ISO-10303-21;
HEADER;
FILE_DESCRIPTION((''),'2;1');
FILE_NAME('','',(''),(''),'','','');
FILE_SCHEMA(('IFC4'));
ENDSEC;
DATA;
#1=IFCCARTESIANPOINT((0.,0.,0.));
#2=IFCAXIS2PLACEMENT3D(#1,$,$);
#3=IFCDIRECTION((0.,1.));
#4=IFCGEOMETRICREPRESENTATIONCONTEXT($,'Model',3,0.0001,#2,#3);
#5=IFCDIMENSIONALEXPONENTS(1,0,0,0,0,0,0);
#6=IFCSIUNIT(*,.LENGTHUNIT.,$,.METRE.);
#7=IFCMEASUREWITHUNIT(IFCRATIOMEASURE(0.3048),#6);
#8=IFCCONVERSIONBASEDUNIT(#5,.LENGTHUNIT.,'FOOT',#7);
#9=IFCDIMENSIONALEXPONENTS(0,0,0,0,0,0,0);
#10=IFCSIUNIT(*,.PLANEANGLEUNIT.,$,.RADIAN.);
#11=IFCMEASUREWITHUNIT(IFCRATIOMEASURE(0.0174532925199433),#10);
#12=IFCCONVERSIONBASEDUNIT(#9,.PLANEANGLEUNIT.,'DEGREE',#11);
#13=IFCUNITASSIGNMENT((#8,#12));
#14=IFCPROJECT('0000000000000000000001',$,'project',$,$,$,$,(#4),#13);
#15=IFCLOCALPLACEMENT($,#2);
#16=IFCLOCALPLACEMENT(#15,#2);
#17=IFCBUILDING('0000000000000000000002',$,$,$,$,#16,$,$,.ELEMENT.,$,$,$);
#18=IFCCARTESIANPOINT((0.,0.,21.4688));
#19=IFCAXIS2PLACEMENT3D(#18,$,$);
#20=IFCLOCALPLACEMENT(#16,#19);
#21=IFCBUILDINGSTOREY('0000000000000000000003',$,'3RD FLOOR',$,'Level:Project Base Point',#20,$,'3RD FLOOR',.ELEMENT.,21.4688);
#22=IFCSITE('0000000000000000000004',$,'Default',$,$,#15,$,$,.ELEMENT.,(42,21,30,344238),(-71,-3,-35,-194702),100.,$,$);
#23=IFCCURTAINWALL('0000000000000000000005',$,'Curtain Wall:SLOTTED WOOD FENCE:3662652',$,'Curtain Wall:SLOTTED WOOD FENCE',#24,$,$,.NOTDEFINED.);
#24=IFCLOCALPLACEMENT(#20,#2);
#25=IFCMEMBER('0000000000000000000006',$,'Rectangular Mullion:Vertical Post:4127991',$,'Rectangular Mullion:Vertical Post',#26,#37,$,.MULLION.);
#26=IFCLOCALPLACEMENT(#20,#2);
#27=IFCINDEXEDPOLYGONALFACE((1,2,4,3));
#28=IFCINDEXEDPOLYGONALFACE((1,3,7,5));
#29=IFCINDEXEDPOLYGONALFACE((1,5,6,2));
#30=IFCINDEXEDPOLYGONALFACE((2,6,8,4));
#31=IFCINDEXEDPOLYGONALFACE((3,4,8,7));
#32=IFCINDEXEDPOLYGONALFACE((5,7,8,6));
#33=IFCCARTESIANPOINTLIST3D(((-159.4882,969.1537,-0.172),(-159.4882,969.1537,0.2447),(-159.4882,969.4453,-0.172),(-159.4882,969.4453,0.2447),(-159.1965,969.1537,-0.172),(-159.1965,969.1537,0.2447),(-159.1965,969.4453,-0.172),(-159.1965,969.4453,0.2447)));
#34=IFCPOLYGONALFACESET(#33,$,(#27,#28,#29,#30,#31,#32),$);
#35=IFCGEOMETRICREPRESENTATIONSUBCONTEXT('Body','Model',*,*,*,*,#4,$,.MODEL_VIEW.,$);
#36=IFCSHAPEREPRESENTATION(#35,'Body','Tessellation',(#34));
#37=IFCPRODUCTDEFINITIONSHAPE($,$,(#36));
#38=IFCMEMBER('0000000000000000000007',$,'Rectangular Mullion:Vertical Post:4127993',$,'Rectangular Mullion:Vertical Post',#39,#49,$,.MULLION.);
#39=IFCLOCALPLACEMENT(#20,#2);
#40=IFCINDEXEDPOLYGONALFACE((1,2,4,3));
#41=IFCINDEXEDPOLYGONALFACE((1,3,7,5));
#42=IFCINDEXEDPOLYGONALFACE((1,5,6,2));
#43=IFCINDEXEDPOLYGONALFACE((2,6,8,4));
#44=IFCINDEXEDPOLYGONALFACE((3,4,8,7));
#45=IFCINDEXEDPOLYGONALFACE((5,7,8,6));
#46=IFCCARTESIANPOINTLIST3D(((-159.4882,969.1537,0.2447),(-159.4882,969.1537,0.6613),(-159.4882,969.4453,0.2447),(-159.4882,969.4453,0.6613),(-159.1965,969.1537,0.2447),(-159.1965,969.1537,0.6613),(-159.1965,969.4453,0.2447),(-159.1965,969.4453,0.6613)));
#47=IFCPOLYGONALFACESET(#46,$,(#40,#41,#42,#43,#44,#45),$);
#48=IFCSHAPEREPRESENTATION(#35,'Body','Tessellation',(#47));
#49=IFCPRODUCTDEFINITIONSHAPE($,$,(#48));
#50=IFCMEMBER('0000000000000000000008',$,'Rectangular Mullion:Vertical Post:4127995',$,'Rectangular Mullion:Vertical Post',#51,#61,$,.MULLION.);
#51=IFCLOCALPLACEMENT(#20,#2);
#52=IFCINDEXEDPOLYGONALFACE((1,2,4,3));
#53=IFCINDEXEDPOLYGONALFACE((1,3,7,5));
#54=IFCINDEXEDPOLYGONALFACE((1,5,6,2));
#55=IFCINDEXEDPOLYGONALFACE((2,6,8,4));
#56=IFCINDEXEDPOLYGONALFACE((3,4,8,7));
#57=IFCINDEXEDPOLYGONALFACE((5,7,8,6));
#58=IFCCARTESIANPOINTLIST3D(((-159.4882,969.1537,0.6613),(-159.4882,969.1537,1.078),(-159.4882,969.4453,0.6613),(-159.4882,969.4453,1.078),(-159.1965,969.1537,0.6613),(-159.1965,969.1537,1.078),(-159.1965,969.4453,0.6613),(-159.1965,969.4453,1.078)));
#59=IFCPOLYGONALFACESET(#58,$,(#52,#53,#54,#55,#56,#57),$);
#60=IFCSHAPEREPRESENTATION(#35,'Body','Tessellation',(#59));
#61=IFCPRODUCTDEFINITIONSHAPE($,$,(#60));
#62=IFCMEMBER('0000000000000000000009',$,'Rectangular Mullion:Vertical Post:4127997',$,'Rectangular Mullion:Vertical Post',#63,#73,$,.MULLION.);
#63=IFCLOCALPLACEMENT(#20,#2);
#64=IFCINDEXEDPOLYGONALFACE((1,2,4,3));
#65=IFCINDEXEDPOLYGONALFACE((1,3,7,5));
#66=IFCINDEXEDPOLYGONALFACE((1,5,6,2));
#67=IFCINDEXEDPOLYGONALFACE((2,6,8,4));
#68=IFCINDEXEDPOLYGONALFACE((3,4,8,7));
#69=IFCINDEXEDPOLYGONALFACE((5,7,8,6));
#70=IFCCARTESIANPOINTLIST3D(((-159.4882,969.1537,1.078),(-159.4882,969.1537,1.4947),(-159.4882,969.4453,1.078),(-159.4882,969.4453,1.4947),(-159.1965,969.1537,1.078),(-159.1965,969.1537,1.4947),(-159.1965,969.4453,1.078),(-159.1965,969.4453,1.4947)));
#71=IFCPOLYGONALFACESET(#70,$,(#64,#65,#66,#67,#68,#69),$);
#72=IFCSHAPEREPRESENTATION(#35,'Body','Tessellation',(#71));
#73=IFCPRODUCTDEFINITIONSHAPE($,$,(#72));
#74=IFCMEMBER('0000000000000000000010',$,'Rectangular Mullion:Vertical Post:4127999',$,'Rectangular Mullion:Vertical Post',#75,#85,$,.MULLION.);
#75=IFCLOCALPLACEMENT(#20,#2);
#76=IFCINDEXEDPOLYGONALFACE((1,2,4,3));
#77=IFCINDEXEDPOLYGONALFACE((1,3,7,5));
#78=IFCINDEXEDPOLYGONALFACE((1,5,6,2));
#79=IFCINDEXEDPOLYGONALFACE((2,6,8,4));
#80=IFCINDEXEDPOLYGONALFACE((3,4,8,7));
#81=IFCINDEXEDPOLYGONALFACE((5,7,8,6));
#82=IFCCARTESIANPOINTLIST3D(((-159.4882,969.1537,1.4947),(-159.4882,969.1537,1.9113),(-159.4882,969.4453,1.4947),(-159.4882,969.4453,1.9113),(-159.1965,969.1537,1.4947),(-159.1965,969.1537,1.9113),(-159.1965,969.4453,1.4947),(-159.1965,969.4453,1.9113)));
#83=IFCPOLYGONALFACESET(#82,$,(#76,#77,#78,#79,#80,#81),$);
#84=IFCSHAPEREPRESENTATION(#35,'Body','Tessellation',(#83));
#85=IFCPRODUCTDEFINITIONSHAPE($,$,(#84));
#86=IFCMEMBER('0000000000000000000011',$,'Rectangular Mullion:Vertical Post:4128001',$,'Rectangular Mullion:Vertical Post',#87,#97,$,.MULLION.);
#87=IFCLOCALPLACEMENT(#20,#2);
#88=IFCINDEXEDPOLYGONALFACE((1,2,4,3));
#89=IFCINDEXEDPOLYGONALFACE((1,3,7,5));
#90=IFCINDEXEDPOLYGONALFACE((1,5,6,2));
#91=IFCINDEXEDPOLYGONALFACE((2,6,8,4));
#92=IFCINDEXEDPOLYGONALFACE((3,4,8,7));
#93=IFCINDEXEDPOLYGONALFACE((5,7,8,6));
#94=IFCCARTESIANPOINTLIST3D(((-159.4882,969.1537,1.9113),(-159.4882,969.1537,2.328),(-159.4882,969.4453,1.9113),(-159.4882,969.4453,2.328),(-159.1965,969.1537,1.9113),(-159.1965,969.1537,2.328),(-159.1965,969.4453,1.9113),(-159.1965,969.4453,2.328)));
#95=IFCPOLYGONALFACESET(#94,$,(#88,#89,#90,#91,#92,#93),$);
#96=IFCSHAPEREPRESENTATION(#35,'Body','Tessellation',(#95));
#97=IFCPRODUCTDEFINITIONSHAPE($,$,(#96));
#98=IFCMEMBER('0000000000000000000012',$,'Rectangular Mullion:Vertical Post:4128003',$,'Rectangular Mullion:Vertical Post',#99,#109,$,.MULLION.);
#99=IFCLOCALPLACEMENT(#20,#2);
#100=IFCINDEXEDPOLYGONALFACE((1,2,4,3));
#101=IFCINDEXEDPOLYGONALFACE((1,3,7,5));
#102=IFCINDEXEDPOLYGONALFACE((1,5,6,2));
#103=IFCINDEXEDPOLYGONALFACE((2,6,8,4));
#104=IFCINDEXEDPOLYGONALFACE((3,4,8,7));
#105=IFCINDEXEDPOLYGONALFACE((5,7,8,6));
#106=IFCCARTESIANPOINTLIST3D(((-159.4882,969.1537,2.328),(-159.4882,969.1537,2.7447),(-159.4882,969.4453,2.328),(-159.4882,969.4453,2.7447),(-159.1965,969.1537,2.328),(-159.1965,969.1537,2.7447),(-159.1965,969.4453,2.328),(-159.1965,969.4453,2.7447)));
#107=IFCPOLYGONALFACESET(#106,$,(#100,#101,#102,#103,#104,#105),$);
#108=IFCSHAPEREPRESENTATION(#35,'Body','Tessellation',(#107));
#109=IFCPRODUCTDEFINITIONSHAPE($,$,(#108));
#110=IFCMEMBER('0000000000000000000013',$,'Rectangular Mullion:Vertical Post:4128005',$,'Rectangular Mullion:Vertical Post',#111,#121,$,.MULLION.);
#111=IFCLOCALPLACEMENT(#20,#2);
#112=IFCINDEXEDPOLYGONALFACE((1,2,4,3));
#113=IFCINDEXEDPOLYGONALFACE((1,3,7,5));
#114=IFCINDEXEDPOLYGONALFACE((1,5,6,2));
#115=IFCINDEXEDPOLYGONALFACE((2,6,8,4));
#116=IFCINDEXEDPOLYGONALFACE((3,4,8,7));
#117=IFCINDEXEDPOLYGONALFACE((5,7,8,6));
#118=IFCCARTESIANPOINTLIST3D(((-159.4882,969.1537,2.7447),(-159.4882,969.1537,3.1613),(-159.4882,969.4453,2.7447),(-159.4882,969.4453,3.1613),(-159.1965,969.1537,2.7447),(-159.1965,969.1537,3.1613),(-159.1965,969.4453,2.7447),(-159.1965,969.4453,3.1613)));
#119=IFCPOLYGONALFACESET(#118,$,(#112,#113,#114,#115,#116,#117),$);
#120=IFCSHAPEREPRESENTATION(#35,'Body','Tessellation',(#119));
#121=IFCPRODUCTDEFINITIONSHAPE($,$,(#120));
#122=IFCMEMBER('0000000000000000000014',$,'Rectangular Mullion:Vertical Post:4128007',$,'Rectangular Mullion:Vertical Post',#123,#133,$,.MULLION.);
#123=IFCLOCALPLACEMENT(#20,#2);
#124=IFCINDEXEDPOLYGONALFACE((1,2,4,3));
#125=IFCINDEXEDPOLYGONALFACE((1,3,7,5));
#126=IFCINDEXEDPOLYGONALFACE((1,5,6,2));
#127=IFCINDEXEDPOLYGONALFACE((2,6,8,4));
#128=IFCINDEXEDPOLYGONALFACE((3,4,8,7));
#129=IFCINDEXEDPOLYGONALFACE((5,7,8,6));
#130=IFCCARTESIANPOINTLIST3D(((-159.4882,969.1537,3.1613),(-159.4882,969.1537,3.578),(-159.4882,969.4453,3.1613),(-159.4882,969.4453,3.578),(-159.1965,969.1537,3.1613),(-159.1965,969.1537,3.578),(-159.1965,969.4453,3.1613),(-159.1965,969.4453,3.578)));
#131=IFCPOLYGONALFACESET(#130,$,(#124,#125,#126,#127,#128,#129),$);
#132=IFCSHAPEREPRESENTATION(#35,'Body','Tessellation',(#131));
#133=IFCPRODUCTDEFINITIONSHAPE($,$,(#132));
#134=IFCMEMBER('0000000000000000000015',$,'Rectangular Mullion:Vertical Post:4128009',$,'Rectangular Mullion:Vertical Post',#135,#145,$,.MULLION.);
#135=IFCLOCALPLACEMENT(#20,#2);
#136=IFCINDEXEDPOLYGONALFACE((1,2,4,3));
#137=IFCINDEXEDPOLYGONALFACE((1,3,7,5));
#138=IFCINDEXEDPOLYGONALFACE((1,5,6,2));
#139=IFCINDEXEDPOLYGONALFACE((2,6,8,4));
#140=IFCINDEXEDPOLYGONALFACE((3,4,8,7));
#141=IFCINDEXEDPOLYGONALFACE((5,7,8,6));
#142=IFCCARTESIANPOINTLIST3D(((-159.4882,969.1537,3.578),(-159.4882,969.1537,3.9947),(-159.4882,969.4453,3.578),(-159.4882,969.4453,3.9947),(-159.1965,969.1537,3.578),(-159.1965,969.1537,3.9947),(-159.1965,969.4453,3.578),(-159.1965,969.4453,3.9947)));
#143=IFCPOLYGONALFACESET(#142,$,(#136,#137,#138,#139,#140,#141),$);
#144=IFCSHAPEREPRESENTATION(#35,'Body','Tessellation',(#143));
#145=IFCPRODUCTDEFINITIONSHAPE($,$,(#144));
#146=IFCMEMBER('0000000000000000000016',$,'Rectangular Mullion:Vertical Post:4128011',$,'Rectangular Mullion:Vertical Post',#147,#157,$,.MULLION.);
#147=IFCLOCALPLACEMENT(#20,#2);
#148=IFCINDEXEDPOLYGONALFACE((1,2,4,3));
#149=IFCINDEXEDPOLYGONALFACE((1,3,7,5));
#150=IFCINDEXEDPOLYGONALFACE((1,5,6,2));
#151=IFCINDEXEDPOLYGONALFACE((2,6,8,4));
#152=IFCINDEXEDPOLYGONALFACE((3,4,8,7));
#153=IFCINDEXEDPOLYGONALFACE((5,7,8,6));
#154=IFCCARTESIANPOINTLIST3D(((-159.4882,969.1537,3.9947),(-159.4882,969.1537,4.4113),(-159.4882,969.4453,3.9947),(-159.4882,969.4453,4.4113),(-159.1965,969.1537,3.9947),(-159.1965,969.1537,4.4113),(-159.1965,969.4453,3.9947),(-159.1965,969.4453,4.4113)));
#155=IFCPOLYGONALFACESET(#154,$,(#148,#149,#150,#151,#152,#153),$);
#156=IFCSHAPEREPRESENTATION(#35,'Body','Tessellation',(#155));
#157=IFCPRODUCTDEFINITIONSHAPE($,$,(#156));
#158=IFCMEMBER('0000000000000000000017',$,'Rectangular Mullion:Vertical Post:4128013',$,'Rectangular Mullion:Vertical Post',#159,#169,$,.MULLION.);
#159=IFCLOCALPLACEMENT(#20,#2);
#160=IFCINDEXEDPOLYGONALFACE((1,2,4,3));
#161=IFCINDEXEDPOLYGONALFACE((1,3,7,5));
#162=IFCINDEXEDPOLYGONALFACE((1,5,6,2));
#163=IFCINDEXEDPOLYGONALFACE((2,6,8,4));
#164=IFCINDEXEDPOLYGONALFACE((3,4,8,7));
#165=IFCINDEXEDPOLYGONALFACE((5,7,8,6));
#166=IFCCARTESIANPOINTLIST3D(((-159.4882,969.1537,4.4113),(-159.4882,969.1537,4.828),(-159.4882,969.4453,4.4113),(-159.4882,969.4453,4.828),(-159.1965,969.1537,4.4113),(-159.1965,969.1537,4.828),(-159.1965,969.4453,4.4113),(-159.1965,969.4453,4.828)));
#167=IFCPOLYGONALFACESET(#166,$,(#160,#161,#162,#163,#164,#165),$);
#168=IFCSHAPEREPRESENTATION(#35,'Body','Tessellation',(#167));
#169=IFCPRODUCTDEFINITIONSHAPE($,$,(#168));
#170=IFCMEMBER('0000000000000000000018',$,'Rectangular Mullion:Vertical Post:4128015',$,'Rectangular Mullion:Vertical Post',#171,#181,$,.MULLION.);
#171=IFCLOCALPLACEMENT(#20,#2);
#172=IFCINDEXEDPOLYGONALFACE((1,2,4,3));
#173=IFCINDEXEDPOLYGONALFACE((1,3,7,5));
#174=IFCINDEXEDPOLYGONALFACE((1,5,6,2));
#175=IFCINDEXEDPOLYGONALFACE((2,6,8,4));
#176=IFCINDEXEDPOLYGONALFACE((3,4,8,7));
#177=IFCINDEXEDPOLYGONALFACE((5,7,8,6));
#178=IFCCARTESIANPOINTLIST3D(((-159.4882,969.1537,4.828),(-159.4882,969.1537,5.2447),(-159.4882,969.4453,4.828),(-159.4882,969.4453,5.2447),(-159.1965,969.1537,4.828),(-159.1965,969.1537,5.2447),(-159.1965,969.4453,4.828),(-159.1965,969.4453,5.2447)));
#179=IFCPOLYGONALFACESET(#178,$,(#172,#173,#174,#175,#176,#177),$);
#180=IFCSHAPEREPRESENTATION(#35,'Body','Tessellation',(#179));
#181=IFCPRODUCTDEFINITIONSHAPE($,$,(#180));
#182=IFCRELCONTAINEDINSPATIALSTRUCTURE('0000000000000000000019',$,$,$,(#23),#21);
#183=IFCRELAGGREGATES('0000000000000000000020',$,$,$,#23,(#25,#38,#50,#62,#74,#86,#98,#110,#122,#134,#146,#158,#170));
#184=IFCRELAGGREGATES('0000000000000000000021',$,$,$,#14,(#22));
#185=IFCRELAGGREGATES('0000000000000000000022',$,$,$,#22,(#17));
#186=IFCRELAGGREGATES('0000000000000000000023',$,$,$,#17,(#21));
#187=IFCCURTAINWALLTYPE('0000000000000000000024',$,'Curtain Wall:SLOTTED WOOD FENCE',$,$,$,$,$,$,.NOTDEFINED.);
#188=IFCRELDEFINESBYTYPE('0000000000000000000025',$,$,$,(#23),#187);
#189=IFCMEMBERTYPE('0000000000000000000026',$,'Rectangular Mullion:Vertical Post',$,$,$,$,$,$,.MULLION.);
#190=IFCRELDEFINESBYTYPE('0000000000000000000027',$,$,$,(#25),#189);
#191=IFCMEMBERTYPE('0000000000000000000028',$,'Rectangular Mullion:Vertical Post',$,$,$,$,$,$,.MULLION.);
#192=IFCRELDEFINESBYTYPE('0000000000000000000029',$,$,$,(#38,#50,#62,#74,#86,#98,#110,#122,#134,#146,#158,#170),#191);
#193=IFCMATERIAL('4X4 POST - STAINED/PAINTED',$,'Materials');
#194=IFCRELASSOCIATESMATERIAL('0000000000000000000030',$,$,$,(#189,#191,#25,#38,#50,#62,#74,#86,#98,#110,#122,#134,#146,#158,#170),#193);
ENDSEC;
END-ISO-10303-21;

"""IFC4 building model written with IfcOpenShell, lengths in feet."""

from ifc_helpers import new_model, entity, si_unit, converted_unit, direction, frame, origin, origin_2d_with_axis, place, context, subcontext, project, spatial, rectangle, extrude, source, transform, mapped, material, material_profile, profile_set, profile_usage, type_object, type_shapes, element, aggregate, save


model = new_model("IFC4")

# Units and contexts
model_context = context("Model", 3, precision=0.0001, world=origin(), true_north=direction((0.0, 1.0)))
body_context = subcontext(model_context, "Body", "Model", "MODEL_VIEW")
ifc_project = project(units=[converted_unit("LENGTHUNIT", "FOOT", entity("IfcRatioMeasure", 0.3048), si_unit("LENGTHUNIT", "METRE"), dimensions=[1, 0, 0, 0, 0, 0, 0]), converted_unit("PLANEANGLEUNIT", "DEGREE", entity("IfcRatioMeasure", 0.0174532925199433), si_unit("PLANEANGLEUNIT", "RADIAN"), dimensions=[0, 0, 0, 0, 0, 0, 0])], contexts=[model_context])

# Site, building, storey
site_placement = place(None, origin())
site = spatial("IfcSite", under=ifc_project, at=site_placement, Name="Default", CompositionType="ELEMENT", RefLatitude=(42, 21, 30, 344238), RefLongitude=(-71, -3, -35, -194702), RefElevation=100.0)
building_placement = place(site_placement, origin())
building = spatial("IfcBuilding", under=site, at=building_placement, CompositionType="ELEMENT")
storey_placement = place(building_placement, frame((0.0, 0.0, 21.4688)))
storey = spatial("IfcBuildingStorey", under=building, at=storey_placement, Name="3RD FLOOR", ObjectType="Level:Project Base Point", LongName="3RD FLOOR", CompositionType="ELEMENT", Elevation=21.4688)

# Curtain wall, members
curtain_wall_type = type_object("IfcCurtainWallType", Name="Curtain Wall:SLOTTED WOOD FENCE", PredefinedType="NOTDEFINED")
curtain_wall_placement = place(storey_placement, frame((0.0, 0.0, -21.4688)))
curtain_wall = element("IfcCurtainWall", 1, at=curtain_wall_placement, inside=storey, type_object=curtain_wall_type, Name="Curtain Wall:SLOTTED WOOD FENCE:3662652", ObjectType="Curtain Wall:SLOTTED WOOD FENCE", PredefinedType="NOTDEFINED")
ifc_material = material(Name="4X4 POST - STAINED/PAINTED", Category="Materials")
ifc_material_profile = material_profile(ifc_material, rectangle(XDim=0.2917, YDim=0.2917, at=origin_2d_with_axis()), Name="Vertical Post")
ifc_profile_set = profile_set([ifc_material_profile], Name="Vertical Post")
ifc_profile_usage_1 = profile_usage(ifc_profile_set)
member_type_1 = type_object("IfcMemberType", Name="Rectangular Mullion:Vertical Post", PredefinedType="MULLION", material=ifc_profile_set)
shared_shape_1 = source(origin(), body_context, "Body", "SweptSolid", [
    extrude(rectangle(XDim=0.2917, YDim=0.2917, at=origin_2d_with_axis()), frame((0.0, -0.2083, -0.4167), z_axis=(0.0, 0.0, 1.0), x_axis=(0.0, -1.0, 0.0)), (0.0, 0.0, 1.0), 0.4167),
])
type_shapes(member_type_1, [shared_shape_1])
member_1_placement = place(storey_placement, frame((-159.5507, 969.2995, -0.172), z_axis=(0.0, 0.0, -1.0), x_axis=(0.0, -1.0, 0.0)))
member_1 = element("IfcMember", 2, at=member_1_placement, type_object=member_type_1, material=ifc_profile_usage_1, Name="Rectangular Mullion:Vertical Post:4127991", ObjectType="Rectangular Mullion:Vertical Post", PredefinedType="MULLION", context=body_context, shape_type="MappedRepresentation", body=[
    mapped(shared_shape_1, transform((0.0, 0.0, 0.0), scale=1.0)),
])
ifc_profile_usage_2 = profile_usage(ifc_profile_set)
member_type_2 = type_object("IfcMemberType", Name="Rectangular Mullion:Vertical Post", PredefinedType="MULLION", material=ifc_profile_set)
shared_shape_2 = source(origin(), body_context, "Body", "SweptSolid", [
    extrude(rectangle(XDim=0.2917, YDim=0.2917, at=origin_2d_with_axis()), frame((0.0, -0.2083, -0.4167), z_axis=(0.0, 0.0, 1.0), x_axis=(0.0, -1.0, 0.0)), (0.0, 0.0, 1.0), 0.4167),
])
type_shapes(member_type_2, [shared_shape_2])
member_2_placement = place(storey_placement, frame((-159.5507, 969.2995, 0.2447), z_axis=(0.0, 0.0, -1.0), x_axis=(0.0, -1.0, 0.0)))
member_2 = element("IfcMember", 3, at=member_2_placement, type_object=member_type_2, material=ifc_profile_usage_2, Name="Rectangular Mullion:Vertical Post:4127993", ObjectType="Rectangular Mullion:Vertical Post", PredefinedType="MULLION", context=body_context, shape_type="MappedRepresentation", body=[
    mapped(shared_shape_2, transform((0.0, 0.0, 0.0), scale=1.0)),
])
ifc_profile_usage_3 = profile_usage(ifc_profile_set)
member_3_placement = place(storey_placement, frame((-159.5507, 969.2995, 0.6613), z_axis=(0.0, 0.0, -1.0), x_axis=(0.0, -1.0, 0.0)))
member_3 = element("IfcMember", 4, at=member_3_placement, type_object=member_type_2, material=ifc_profile_usage_3, Name="Rectangular Mullion:Vertical Post:4127995", ObjectType="Rectangular Mullion:Vertical Post", PredefinedType="MULLION", context=body_context, shape_type="MappedRepresentation", body=[
    mapped(shared_shape_2, transform((0.0, 0.0, 0.0), scale=1.0)),
])
ifc_profile_usage_4 = profile_usage(ifc_profile_set)
member_4_placement = place(storey_placement, frame((-159.5507, 969.2995, 1.078), z_axis=(0.0, 0.0, -1.0), x_axis=(0.0, -1.0, 0.0)))
member_4 = element("IfcMember", 5, at=member_4_placement, type_object=member_type_2, material=ifc_profile_usage_4, Name="Rectangular Mullion:Vertical Post:4127997", ObjectType="Rectangular Mullion:Vertical Post", PredefinedType="MULLION", context=body_context, shape_type="MappedRepresentation", body=[
    mapped(shared_shape_2, transform((0.0, 0.0, 0.0), scale=1.0)),
])
ifc_profile_usage_5 = profile_usage(ifc_profile_set)
member_5_placement = place(storey_placement, frame((-159.5507, 969.2995, 1.4947), z_axis=(0.0, 0.0, -1.0), x_axis=(0.0, -1.0, 0.0)))
member_5 = element("IfcMember", 6, at=member_5_placement, type_object=member_type_2, material=ifc_profile_usage_5, Name="Rectangular Mullion:Vertical Post:4127999", ObjectType="Rectangular Mullion:Vertical Post", PredefinedType="MULLION", context=body_context, shape_type="MappedRepresentation", body=[
    mapped(shared_shape_2, transform((0.0, 0.0, 0.0), scale=1.0)),
])
ifc_profile_usage_6 = profile_usage(ifc_profile_set)
member_6_placement = place(storey_placement, frame((-159.5507, 969.2995, 1.9113), z_axis=(0.0, 0.0, -1.0), x_axis=(0.0, -1.0, 0.0)))
member_6 = element("IfcMember", 7, at=member_6_placement, type_object=member_type_2, material=ifc_profile_usage_6, Name="Rectangular Mullion:Vertical Post:4128001", ObjectType="Rectangular Mullion:Vertical Post", PredefinedType="MULLION", context=body_context, shape_type="MappedRepresentation", body=[
    mapped(shared_shape_2, transform((0.0, 0.0, 0.0), scale=1.0)),
])
ifc_profile_usage_7 = profile_usage(ifc_profile_set)
member_7_placement = place(storey_placement, frame((-159.5507, 969.2995, 2.328), z_axis=(0.0, 0.0, -1.0), x_axis=(0.0, -1.0, 0.0)))
member_7 = element("IfcMember", 8, at=member_7_placement, type_object=member_type_2, material=ifc_profile_usage_7, Name="Rectangular Mullion:Vertical Post:4128003", ObjectType="Rectangular Mullion:Vertical Post", PredefinedType="MULLION", context=body_context, shape_type="MappedRepresentation", body=[
    mapped(shared_shape_2, transform((0.0, 0.0, 0.0), scale=1.0)),
])
ifc_profile_usage_8 = profile_usage(ifc_profile_set)
member_8_placement = place(storey_placement, frame((-159.5507, 969.2995, 2.7447), z_axis=(0.0, 0.0, -1.0), x_axis=(0.0, -1.0, 0.0)))
member_8 = element("IfcMember", 9, at=member_8_placement, type_object=member_type_2, material=ifc_profile_usage_8, Name="Rectangular Mullion:Vertical Post:4128005", ObjectType="Rectangular Mullion:Vertical Post", PredefinedType="MULLION", context=body_context, shape_type="MappedRepresentation", body=[
    mapped(shared_shape_2, transform((0.0, 0.0, 0.0), scale=1.0)),
])
ifc_profile_usage_9 = profile_usage(ifc_profile_set)
member_9_placement = place(storey_placement, frame((-159.5507, 969.2995, 3.1613), z_axis=(0.0, 0.0, -1.0), x_axis=(0.0, -1.0, 0.0)))
member_9 = element("IfcMember", 10, at=member_9_placement, type_object=member_type_2, material=ifc_profile_usage_9, Name="Rectangular Mullion:Vertical Post:4128007", ObjectType="Rectangular Mullion:Vertical Post", PredefinedType="MULLION", context=body_context, shape_type="MappedRepresentation", body=[
    mapped(shared_shape_2, transform((0.0, 0.0, 0.0), scale=1.0)),
])
ifc_profile_usage_10 = profile_usage(ifc_profile_set)
member_10_placement = place(storey_placement, frame((-159.5507, 969.2995, 3.578), z_axis=(0.0, 0.0, -1.0), x_axis=(0.0, -1.0, 0.0)))
member_10 = element("IfcMember", 11, at=member_10_placement, type_object=member_type_2, material=ifc_profile_usage_10, Name="Rectangular Mullion:Vertical Post:4128009", ObjectType="Rectangular Mullion:Vertical Post", PredefinedType="MULLION", context=body_context, shape_type="MappedRepresentation", body=[
    mapped(shared_shape_2, transform((0.0, 0.0, 0.0), scale=1.0)),
])
ifc_profile_usage_11 = profile_usage(ifc_profile_set)
member_11_placement = place(storey_placement, frame((-159.5507, 969.2995, 3.9947), z_axis=(0.0, 0.0, -1.0), x_axis=(0.0, -1.0, 0.0)))
member_11 = element("IfcMember", 12, at=member_11_placement, type_object=member_type_2, material=ifc_profile_usage_11, Name="Rectangular Mullion:Vertical Post:4128011", ObjectType="Rectangular Mullion:Vertical Post", PredefinedType="MULLION", context=body_context, shape_type="MappedRepresentation", body=[
    mapped(shared_shape_2, transform((0.0, 0.0, 0.0), scale=1.0)),
])
ifc_profile_usage_12 = profile_usage(ifc_profile_set)
member_12_placement = place(storey_placement, frame((-159.5507, 969.2995, 4.4113), z_axis=(0.0, 0.0, -1.0), x_axis=(0.0, -1.0, 0.0)))
member_12 = element("IfcMember", 13, at=member_12_placement, type_object=member_type_2, material=ifc_profile_usage_12, Name="Rectangular Mullion:Vertical Post:4128013", ObjectType="Rectangular Mullion:Vertical Post", PredefinedType="MULLION", context=body_context, shape_type="MappedRepresentation", body=[
    mapped(shared_shape_2, transform((0.0, 0.0, 0.0), scale=1.0)),
])
ifc_profile_usage_13 = profile_usage(ifc_profile_set)
member_13_placement = place(storey_placement, frame((-159.5507, 969.2995, 4.828), z_axis=(0.0, 0.0, -1.0), x_axis=(0.0, -1.0, 0.0)))
member_13 = element("IfcMember", 14, at=member_13_placement, type_object=member_type_2, material=ifc_profile_usage_13, Name="Rectangular Mullion:Vertical Post:4128015", ObjectType="Rectangular Mullion:Vertical Post", PredefinedType="MULLION", context=body_context, shape_type="MappedRepresentation", body=[
    mapped(shared_shape_2, transform((0.0, 0.0, 0.0), scale=1.0)),
])
aggregate(curtain_wall, [member_1, member_2, member_3, member_4, member_5, member_6, member_7, member_8, member_9, member_10, member_11, member_12, member_13])

save(model, "model.ifc")
